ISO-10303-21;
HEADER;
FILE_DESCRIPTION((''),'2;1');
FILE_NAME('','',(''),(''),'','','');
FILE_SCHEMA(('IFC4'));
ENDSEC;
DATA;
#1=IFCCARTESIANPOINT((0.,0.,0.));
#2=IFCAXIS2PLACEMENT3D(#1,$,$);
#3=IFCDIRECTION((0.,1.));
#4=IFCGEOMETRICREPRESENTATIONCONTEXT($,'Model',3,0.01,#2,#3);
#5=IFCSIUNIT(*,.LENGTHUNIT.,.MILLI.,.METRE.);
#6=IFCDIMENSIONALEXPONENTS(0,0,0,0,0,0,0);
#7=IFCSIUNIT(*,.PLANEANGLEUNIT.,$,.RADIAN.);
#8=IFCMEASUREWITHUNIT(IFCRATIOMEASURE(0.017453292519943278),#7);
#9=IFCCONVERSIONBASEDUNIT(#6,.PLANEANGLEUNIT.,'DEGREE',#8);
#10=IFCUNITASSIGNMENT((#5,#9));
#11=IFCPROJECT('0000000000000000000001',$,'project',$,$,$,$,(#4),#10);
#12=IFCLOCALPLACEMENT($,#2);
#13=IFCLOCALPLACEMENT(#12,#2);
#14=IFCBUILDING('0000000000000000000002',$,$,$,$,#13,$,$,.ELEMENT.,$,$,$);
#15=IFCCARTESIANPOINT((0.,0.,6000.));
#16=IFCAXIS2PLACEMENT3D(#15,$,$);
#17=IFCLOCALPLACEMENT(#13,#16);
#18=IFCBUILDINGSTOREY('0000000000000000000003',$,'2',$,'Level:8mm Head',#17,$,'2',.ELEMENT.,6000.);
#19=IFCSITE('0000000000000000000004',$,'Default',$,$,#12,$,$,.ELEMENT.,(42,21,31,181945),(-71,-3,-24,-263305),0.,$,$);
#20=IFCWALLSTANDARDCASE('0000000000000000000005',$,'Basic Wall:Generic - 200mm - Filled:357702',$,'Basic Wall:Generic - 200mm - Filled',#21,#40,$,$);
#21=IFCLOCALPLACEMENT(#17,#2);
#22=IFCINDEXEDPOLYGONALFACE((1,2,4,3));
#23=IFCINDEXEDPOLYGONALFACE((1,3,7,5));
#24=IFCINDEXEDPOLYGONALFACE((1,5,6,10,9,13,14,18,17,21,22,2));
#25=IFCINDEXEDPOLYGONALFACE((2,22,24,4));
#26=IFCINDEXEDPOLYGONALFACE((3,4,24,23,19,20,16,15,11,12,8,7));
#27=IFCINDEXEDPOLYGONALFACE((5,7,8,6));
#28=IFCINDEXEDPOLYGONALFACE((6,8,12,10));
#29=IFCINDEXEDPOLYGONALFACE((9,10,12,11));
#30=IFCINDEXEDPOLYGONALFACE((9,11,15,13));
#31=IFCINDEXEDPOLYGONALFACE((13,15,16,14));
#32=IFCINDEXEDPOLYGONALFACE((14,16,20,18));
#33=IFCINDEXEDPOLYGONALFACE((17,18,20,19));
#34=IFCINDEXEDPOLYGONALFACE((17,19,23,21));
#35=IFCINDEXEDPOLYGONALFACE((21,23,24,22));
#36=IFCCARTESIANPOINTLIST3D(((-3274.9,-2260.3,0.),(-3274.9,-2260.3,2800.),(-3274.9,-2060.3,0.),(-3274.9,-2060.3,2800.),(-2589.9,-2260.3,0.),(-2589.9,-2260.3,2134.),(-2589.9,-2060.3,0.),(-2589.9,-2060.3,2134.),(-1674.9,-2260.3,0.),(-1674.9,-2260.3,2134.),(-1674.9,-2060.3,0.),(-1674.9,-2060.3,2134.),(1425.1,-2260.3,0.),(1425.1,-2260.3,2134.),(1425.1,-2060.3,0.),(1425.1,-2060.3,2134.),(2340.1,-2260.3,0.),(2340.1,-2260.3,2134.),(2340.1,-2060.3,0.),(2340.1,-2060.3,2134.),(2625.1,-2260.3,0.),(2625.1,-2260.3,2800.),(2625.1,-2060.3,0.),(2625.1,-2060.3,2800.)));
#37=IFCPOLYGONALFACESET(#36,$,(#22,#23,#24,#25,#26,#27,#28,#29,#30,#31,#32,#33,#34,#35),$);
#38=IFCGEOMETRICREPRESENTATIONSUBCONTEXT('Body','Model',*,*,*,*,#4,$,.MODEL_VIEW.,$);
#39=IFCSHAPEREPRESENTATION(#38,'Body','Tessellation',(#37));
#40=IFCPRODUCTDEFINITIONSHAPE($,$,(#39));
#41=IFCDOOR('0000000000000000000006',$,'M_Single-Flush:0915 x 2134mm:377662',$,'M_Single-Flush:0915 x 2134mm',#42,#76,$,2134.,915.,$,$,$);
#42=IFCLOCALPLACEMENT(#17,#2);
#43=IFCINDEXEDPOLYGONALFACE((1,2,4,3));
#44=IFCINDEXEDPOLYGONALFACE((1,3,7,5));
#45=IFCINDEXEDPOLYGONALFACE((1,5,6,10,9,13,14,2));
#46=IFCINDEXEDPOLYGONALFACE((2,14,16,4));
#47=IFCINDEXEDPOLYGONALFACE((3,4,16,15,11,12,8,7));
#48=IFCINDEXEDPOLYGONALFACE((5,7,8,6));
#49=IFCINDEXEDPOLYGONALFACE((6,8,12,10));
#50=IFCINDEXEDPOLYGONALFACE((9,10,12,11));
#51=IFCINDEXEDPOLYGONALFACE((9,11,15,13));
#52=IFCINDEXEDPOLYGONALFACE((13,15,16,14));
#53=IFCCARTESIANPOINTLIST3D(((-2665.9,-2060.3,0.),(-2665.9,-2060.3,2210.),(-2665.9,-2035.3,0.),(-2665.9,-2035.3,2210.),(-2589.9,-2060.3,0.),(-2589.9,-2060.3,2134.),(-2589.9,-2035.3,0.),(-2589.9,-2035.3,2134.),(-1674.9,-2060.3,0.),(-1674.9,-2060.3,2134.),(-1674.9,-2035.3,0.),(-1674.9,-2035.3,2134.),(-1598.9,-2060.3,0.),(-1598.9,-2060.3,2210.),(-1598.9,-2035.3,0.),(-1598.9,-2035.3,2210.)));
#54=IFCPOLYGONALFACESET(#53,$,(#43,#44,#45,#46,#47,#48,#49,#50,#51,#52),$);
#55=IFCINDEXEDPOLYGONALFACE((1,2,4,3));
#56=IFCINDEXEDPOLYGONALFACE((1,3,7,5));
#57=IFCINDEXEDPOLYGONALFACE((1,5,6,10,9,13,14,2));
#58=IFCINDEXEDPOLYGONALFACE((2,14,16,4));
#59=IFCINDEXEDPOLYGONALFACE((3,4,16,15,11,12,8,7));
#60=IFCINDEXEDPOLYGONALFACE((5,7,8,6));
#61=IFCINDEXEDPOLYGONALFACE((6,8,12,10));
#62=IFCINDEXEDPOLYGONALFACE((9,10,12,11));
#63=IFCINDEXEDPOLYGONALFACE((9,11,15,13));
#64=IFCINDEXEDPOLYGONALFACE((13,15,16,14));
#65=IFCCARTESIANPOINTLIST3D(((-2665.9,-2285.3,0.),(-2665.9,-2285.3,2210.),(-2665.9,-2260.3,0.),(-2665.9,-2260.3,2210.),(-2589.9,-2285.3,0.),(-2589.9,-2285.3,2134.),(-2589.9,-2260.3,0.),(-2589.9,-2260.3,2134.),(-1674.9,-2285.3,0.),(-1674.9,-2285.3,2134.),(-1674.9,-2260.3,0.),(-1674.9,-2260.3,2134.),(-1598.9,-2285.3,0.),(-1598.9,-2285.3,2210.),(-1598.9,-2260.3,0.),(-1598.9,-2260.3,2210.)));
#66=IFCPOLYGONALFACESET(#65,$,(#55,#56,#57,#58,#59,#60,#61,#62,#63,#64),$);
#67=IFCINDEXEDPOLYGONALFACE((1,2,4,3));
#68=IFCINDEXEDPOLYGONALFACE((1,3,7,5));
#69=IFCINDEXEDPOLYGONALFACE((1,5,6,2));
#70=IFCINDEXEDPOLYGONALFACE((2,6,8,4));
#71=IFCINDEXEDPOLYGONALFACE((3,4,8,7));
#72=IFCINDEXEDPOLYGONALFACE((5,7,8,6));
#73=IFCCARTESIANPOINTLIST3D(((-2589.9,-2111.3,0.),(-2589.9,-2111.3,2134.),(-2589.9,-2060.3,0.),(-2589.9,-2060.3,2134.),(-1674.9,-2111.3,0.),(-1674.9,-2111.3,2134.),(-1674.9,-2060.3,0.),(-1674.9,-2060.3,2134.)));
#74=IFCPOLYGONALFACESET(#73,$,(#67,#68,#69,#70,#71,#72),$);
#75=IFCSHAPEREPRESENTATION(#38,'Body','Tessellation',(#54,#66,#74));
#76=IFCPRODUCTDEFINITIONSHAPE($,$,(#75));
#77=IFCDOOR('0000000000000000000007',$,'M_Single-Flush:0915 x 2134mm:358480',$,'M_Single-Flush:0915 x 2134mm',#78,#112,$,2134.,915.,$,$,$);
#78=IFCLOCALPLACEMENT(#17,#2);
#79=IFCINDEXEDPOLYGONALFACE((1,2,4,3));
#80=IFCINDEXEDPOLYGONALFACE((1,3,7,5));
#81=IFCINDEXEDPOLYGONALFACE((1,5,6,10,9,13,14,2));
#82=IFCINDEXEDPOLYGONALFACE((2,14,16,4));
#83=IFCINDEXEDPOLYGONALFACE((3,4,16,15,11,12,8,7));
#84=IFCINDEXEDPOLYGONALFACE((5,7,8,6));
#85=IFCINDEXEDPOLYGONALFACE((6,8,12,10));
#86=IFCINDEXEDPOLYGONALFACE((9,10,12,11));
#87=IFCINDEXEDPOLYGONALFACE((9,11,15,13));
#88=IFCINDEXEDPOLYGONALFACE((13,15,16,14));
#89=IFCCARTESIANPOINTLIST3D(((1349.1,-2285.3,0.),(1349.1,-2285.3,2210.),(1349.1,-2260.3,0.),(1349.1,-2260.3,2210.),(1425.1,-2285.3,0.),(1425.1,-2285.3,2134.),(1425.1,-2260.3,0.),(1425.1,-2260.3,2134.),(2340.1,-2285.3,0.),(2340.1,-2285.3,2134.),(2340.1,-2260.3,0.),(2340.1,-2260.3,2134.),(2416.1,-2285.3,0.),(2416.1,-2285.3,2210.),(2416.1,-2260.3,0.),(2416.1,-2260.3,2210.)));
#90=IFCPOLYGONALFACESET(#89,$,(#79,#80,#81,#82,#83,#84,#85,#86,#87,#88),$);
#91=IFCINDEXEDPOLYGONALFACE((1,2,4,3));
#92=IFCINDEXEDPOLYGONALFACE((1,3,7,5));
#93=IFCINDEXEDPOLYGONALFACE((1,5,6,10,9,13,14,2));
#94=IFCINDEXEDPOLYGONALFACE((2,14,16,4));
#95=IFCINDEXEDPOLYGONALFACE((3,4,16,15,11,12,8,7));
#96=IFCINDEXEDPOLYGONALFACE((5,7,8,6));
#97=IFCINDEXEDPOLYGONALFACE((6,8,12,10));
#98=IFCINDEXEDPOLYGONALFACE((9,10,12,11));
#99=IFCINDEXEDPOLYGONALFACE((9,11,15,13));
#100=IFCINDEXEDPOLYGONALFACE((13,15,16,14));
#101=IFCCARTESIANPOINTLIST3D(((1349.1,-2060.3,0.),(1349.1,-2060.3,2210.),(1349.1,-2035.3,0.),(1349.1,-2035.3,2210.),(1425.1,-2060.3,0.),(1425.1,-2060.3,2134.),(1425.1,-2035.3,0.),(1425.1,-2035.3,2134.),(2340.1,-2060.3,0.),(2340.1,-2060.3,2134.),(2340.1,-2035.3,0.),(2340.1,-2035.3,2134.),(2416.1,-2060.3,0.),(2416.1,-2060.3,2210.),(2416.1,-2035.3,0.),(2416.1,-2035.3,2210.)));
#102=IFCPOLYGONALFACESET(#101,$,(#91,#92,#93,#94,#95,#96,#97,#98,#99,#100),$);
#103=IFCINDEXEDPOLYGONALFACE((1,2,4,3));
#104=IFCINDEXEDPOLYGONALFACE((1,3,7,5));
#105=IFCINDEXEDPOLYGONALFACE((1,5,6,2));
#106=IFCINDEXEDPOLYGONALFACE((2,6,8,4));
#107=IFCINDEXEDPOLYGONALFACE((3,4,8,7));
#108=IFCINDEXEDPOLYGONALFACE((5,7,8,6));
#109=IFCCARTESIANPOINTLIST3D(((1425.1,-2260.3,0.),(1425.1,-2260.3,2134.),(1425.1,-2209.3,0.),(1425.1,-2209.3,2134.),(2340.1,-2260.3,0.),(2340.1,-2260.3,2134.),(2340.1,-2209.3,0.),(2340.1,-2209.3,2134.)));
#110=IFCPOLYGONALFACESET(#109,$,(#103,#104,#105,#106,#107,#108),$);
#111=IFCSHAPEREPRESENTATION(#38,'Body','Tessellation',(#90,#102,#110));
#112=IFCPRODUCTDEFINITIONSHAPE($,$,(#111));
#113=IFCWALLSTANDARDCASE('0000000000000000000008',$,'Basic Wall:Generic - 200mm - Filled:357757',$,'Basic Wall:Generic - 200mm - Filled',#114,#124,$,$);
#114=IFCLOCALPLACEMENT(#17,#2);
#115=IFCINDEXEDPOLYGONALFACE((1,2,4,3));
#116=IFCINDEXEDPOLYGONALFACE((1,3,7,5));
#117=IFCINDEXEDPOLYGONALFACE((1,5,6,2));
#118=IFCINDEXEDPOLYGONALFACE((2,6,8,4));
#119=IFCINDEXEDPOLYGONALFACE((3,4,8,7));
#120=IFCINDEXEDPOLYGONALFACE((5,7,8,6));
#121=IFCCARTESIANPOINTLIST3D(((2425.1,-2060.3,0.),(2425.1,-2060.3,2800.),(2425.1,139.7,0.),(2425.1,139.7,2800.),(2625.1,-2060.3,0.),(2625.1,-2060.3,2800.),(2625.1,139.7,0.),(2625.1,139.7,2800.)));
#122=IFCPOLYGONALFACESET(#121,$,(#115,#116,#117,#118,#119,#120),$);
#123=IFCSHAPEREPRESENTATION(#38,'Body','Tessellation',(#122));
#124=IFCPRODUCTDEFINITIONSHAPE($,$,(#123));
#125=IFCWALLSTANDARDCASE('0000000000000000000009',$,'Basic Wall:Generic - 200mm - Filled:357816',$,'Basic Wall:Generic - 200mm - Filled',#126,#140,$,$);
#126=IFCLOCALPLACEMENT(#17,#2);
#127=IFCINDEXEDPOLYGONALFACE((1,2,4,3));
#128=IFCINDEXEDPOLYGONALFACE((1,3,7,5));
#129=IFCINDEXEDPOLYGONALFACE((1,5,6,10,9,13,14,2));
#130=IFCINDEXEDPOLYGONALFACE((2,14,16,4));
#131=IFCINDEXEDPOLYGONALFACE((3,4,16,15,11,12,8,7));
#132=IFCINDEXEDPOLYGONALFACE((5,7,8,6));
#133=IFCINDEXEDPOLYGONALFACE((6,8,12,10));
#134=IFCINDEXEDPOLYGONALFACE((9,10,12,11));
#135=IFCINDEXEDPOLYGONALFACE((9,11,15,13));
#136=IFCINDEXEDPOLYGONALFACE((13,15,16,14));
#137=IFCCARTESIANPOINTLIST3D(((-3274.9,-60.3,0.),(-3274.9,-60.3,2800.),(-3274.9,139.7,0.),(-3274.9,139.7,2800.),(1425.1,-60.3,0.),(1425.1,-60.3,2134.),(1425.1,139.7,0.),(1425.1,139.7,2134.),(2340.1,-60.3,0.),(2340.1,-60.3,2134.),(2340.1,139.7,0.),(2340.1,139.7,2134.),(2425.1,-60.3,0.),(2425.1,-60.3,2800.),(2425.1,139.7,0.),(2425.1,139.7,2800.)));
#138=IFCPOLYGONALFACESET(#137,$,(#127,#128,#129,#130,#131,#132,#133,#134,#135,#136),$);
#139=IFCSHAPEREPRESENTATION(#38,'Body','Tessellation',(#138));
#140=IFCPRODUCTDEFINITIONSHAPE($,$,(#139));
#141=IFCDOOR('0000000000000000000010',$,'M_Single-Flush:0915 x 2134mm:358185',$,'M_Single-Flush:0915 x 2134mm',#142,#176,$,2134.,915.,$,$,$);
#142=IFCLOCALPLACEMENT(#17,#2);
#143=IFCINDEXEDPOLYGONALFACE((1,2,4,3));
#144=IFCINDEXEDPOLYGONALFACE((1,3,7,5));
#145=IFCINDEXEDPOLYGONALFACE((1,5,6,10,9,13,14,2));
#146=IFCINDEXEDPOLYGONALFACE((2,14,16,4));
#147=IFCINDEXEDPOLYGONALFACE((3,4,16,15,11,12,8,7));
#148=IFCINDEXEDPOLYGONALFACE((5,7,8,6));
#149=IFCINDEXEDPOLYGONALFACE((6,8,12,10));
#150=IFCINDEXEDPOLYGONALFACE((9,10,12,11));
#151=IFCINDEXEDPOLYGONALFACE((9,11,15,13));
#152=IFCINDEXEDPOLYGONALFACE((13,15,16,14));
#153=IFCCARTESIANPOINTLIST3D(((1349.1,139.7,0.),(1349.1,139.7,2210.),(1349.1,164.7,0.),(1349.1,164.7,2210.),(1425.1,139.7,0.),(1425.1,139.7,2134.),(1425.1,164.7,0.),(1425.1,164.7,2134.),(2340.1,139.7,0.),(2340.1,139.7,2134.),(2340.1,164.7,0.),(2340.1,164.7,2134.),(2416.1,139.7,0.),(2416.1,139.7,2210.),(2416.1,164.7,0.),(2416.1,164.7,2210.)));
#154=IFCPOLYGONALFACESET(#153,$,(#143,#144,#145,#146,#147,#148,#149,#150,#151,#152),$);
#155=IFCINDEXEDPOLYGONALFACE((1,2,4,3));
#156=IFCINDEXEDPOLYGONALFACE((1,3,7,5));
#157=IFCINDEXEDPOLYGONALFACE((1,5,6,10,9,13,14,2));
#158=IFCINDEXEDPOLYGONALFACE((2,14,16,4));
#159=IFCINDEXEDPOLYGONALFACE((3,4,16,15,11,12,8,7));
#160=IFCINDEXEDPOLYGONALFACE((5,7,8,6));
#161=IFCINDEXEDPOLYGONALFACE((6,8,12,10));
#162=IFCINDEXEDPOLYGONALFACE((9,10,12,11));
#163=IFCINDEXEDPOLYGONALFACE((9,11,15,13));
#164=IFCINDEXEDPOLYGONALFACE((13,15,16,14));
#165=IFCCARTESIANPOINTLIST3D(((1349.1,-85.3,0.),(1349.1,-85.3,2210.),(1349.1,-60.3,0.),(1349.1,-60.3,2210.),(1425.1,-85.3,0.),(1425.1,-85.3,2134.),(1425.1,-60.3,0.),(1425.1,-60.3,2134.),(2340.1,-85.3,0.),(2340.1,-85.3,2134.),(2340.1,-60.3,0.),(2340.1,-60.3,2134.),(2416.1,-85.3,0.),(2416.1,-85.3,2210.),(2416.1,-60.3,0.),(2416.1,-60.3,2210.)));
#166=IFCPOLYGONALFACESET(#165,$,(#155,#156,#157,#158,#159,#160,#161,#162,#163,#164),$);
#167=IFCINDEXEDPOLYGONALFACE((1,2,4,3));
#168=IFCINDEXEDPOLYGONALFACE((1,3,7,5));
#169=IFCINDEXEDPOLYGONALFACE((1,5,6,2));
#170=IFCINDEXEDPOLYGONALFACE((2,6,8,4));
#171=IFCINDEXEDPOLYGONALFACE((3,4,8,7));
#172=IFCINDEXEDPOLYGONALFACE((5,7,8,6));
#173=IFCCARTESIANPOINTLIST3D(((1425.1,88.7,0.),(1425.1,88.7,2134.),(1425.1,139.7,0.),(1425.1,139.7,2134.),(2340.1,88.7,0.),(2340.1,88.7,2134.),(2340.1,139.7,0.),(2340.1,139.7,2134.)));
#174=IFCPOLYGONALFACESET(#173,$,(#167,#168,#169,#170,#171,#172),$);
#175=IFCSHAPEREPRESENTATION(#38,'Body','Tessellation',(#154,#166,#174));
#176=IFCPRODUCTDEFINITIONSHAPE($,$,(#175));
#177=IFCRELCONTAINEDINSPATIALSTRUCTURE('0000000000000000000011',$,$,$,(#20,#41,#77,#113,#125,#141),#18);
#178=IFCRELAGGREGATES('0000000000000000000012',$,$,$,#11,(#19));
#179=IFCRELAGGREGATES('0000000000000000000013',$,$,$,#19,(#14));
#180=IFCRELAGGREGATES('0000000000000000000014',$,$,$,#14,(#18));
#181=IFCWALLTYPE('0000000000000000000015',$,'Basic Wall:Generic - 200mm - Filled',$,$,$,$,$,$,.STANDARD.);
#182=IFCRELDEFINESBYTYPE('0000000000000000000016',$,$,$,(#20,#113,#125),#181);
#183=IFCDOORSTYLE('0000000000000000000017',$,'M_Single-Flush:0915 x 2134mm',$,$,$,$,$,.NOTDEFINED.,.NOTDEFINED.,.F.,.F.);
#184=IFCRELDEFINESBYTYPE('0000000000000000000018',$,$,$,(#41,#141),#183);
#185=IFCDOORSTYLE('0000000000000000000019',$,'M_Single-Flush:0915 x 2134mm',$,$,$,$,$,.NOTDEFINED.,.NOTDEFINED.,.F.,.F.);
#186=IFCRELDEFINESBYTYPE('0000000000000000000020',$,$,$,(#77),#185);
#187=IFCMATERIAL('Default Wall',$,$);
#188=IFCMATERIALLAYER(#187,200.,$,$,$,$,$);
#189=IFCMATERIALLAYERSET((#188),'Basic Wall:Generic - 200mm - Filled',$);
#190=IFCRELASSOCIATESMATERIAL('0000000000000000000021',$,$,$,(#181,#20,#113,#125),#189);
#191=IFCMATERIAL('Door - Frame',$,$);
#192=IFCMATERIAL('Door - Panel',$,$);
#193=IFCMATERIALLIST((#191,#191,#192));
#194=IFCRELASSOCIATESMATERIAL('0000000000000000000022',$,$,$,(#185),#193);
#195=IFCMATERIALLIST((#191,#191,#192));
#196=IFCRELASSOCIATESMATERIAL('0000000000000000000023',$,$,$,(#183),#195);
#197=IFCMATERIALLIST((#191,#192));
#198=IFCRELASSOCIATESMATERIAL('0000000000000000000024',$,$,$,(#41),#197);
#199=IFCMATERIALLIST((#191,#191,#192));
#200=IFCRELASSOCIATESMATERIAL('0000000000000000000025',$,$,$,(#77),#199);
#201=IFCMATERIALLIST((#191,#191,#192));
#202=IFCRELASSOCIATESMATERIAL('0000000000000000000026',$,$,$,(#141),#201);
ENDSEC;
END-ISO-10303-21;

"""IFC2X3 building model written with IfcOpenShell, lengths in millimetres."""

from ifc_helpers import new_model, entity, si_unit, converted_unit, direction, frame, frame_2d, origin, place, context, subcontext, project, spatial, polyline, rectangle, outline, extrude, source, transform, mapped, material, material_list, layer, layer_set, layer_usage, type_object, type_shapes, element, fill, save


model = new_model("IFC2X3")

# Units and contexts
model_context = context("Model", 3, precision=0.01, world=origin(), true_north=direction((0.0, 1.0)))
body_context = subcontext(model_context, "Body", "Model", "MODEL_VIEW")
ifc_project = project(units=[si_unit("LENGTHUNIT", "METRE", prefix="MILLI"), converted_unit("PLANEANGLEUNIT", "DEGREE", entity("IfcRatioMeasure", 0.017453292519943278), si_unit("PLANEANGLEUNIT", "RADIAN"), dimensions=[0, 0, 0, 0, 0, 0, 0])], contexts=[model_context])

# Site, building, storey
site_placement = place(None, origin())
site = spatial("IfcSite", under=ifc_project, at=site_placement, Name="Default", CompositionType="ELEMENT", RefLatitude=(42, 21, 31, 181945), RefLongitude=(-71, -3, -24, -263305), RefElevation=0.0)
building_placement = place(site_placement, origin())
building = spatial("IfcBuilding", under=site, at=building_placement, CompositionType="ELEMENT")
storey_placement = place(building_placement, frame((0.0, 0.0, 6000.0)))
storey = spatial("IfcBuildingStorey", under=building, at=storey_placement, Name="2", ObjectType="Level:8mm Head", LongName="2", CompositionType="ELEMENT", Elevation=6000.0)

# Shared definitions
ifc_material_1 = material(Name="Default Wall")
ifc_layer_1 = layer(ifc_material_1, 200.0)
ifc_layer_set_1 = layer_set([ifc_layer_1], Name="Basic Wall:Generic - 200mm - Filled")
wall_type_1 = type_object("IfcWallType", Name="Basic Wall:Generic - 200mm - Filled", PredefinedType="STANDARD", material=ifc_layer_set_1)
ifc_material_2 = material(Name="Door - Frame")
ifc_material_3 = material(Name="Door - Panel")
ifc_material_list_1 = material_list([ifc_material_2, ifc_material_2, ifc_material_3])
door_style_1 = type_object("IfcDoorStyle", Name="M_Single-Flush:0915 x 2134mm", ConstructionType="NOTDEFINED", OperationType="NOTDEFINED", ParameterTakesPrecedence=False, Sizeable=False, material=ifc_material_list_1)
shared_shape_1 = source(origin(), body_context, "Body", "SweptSolid", [
    extrude(outline(polyline([(-533.5, -1124.0), (533.5, -1124.0), (533.5, 1086.0), (457.5, 1086.0), (457.5, -1048.0), (-457.5, -1048.0), (-457.5, 1086.0), (-533.5, 1086.0), (-533.5, -1124.0)])), frame((457.5, 200.0, 1086.0), z_axis=(0.0, 1.0, 0.0), x_axis=(1.0, 0.0, 0.0)), (0.0, 0.0, 1.0), 25.0),
    extrude(outline(polyline([(-1124.0, -533.5), (1086.0, -533.5), (1086.0, -457.5), (-1048.0, -457.5), (-1048.0, 457.5), (1086.0, 457.5), (1086.0, 533.5), (-1124.0, 533.5), (-1124.0, -533.5)])), frame((457.5, -25.0, 1086.0), z_axis=(0.0, 1.0, 0.0), x_axis=(0.0, 0.0, -1.0)), (0.0, 0.0, 1.0), 25.0),
    extrude(rectangle(XDim=51.0, YDim=915.0, at=frame_2d((0.0, 0.0), x_axis=(1.0, 0.0))), frame((457.5, 174.5, 0.0), z_axis=(0.0, 0.0, 1.0), x_axis=(0.0, 1.0, 0.0)), (0.0, 0.0, 1.0), 2134.0),
])
type_shapes(door_style_1, [shared_shape_1])

# Wall, openings, doors
ifc_layer_usage_1 = layer_usage(ifc_layer_set_1, "AXIS2", "NEGATIVE", 100.0)
wall_1_placement = place(storey_placement, frame((-3274.9, -2160.3, 0.0)))
wall_1 = element("IfcWallStandardCase", 1, at=wall_1_placement, inside=storey, type_object=wall_type_1, material=ifc_layer_usage_1, Name="Basic Wall:Generic - 200mm - Filled:357702", ObjectType="Basic Wall:Generic - 200mm - Filled", context=body_context, shape_type="SweptSolid", body=[
    extrude(rectangle(XDim=5900.0, YDim=200.0, at=frame_2d((2950.0, 0.0), x_axis=(1.0, 0.0))), origin(), (0.0, 0.0, 1.0), 2800.0),
])
opening_1_placement = place(wall_1_placement, frame((5615.0, 100.0, 0.0)))
opening_1 = element("IfcOpeningElement", 2, at=opening_1_placement, cuts=wall_1, ObjectType="Opening", context=body_context, shape_type="SweptSolid", body=[
    extrude(rectangle(XDim=915.0, YDim=2134.0, at=frame_2d((1067.0, 457.5), x_axis=(0.0, 1.0))), frame((0.0, 0.0, 0.0), z_axis=(0.0, -1.0, 0.0), x_axis=(0.0, 0.0, 1.0)), (0.0, 0.0, 1.0), 200.0),
])
opening_2_placement = place(wall_1_placement, frame((685.0, -100.0, 0.0)))
opening_2 = element("IfcOpeningElement", 3, at=opening_2_placement, cuts=wall_1, ObjectType="Opening", context=body_context, shape_type="SweptSolid", body=[
    extrude(rectangle(XDim=915.0, YDim=2134.0, at=frame_2d((1067.0, 457.5), x_axis=(0.0, -1.0))), frame((0.0, 0.0, 0.0), z_axis=(0.0, 1.0, 0.0), x_axis=(0.0, 0.0, 1.0)), (0.0, 0.0, 1.0), 200.0),
])
ifc_material_list_2 = material_list([ifc_material_2, ifc_material_3])
ifc_material_list_3 = material_list([ifc_material_2, ifc_material_2, ifc_material_3])
door_style_2 = type_object("IfcDoorStyle", Name="M_Single-Flush:0915 x 2134mm", ConstructionType="NOTDEFINED", OperationType="NOTDEFINED", ParameterTakesPrecedence=False, Sizeable=False, material=ifc_material_list_3)
shared_shape_2 = source(origin(), body_context, "Body", "SweptSolid", [
    extrude(outline(polyline([(-533.5, -1124.0), (533.5, -1124.0), (533.5, 1086.0), (457.5, 1086.0), (457.5, -1048.0), (-457.5, -1048.0), (-457.5, 1086.0), (-533.5, 1086.0), (-533.5, -1124.0)])), frame((457.5, 225.0, 1086.0), z_axis=(0.0, -1.0, 0.0), x_axis=(-1.0, 0.0, 0.0)), (0.0, 0.0, 1.0), 25.0),
    extrude(outline(polyline([(-1124.0, -533.5), (1086.0, -533.5), (1086.0, -457.5), (-1048.0, -457.5), (-1048.0, 457.5), (1086.0, 457.5), (1086.0, 533.5), (-1124.0, 533.5), (-1124.0, -533.5)])), frame((457.5, 0.0, 1086.0), z_axis=(0.0, -1.0, 0.0), x_axis=(0.0, 0.0, -1.0)), (0.0, 0.0, 1.0), 25.0),
    extrude(rectangle(XDim=915.0, YDim=51.0, at=frame_2d((0.0, 0.0), x_axis=(1.0, 0.0))), frame((457.5, 174.5, 0.0)), (0.0, 0.0, 1.0), 2134.0),
])
type_shapes(door_style_2, [shared_shape_2])
door_1_placement = place(opening_2_placement, origin())
door_1 = element("IfcDoor", 4, at=door_1_placement, inside=storey, type_object=door_style_2, material=ifc_material_list_2, Name="M_Single-Flush:0915 x 2134mm:377662", ObjectType="M_Single-Flush:0915 x 2134mm", OverallHeight=2134.0, OverallWidth=915.0, context=body_context, shape_type="MappedRepresentation", body=[
    mapped(shared_shape_2, transform((0.0, 0.0, 0.0), scale=1.0)),
])
fill(opening_2, door_1)
ifc_material_list_4 = material_list([ifc_material_2, ifc_material_2, ifc_material_3])
door_2_placement = place(opening_1_placement, frame((0.0, 0.0, 0.0), z_axis=(0.0, 0.0, 1.0), x_axis=(-1.0, 0.0, 0.0)))
door_2 = element("IfcDoor", 5, at=door_2_placement, inside=storey, type_object=door_style_1, material=ifc_material_list_4, Name="M_Single-Flush:0915 x 2134mm:358480", ObjectType="M_Single-Flush:0915 x 2134mm", OverallHeight=2134.0, OverallWidth=915.0, context=body_context, shape_type="MappedRepresentation", body=[
    mapped(shared_shape_1, transform((0.0, 0.0, 0.0), scale=1.0)),
])
fill(opening_1, door_2)

# Wall
ifc_layer_usage_2 = layer_usage(ifc_layer_set_1, "AXIS2", "NEGATIVE", 100.0)
wall_2_placement = place(storey_placement, frame((2525.1, -2060.3, 0.0), z_axis=(0.0, 0.0, 1.0), x_axis=(0.0, 1.0, 0.0)))
element("IfcWallStandardCase", 6, at=wall_2_placement, inside=storey, type_object=wall_type_1, material=ifc_layer_usage_2, Name="Basic Wall:Generic - 200mm - Filled:357757", ObjectType="Basic Wall:Generic - 200mm - Filled", context=body_context, shape_type="SweptSolid", body=[
    extrude(rectangle(XDim=2200.0, YDim=200.0, at=frame_2d((1100.0, 0.0), x_axis=(-1.0, 0.0))), origin(), (0.0, 0.0, 1.0), 2800.0),
])

# Wall, opening, door
ifc_layer_usage_3 = layer_usage(ifc_layer_set_1, "AXIS2", "NEGATIVE", 100.0)
wall_3_placement = place(storey_placement, frame((2425.1, 39.7, 0.0), z_axis=(0.0, 0.0, 1.0), x_axis=(-1.0, 0.0, 0.0)))
wall_3 = element("IfcWallStandardCase", 7, at=wall_3_placement, inside=storey, type_object=wall_type_1, material=ifc_layer_usage_3, Name="Basic Wall:Generic - 200mm - Filled:357816", ObjectType="Basic Wall:Generic - 200mm - Filled", context=body_context, shape_type="SweptSolid", body=[
    extrude(rectangle(XDim=5700.0, YDim=200.0, at=frame_2d((2850.0, 0.0), x_axis=(1.0, 0.0))), origin(), (0.0, 0.0, 1.0), 2800.0),
])
opening_3_placement = place(wall_3_placement, frame((1000.0, 100.0, 0.0)))
opening_3 = element("IfcOpeningElement", 8, at=opening_3_placement, cuts=wall_3, ObjectType="Opening", context=body_context, shape_type="SweptSolid", body=[
    extrude(rectangle(XDim=915.0, YDim=2134.0, at=frame_2d((1067.0, 457.5), x_axis=(0.0, -1.0))), frame((0.0, 0.0, 0.0), z_axis=(0.0, -1.0, 0.0), x_axis=(0.0, 0.0, 1.0)), (0.0, 0.0, 1.0), 200.0),
])
ifc_material_list_5 = material_list([ifc_material_2, ifc_material_2, ifc_material_3])
door_3_placement = place(opening_3_placement, frame((0.0, 0.0, 0.0), z_axis=(0.0, 0.0, 1.0), x_axis=(-1.0, 0.0, 0.0)))
door_3 = element("IfcDoor", 9, at=door_3_placement, inside=storey, type_object=door_style_2, material=ifc_material_list_5, Name="M_Single-Flush:0915 x 2134mm:358185", ObjectType="M_Single-Flush:0915 x 2134mm", OverallHeight=2134.0, OverallWidth=915.0, context=body_context, shape_type="MappedRepresentation", body=[
    mapped(shared_shape_2, transform((0.0, 0.0, 0.0), scale=1.0)),
])
fill(opening_3, door_3)

save(model, "model.ifc")
